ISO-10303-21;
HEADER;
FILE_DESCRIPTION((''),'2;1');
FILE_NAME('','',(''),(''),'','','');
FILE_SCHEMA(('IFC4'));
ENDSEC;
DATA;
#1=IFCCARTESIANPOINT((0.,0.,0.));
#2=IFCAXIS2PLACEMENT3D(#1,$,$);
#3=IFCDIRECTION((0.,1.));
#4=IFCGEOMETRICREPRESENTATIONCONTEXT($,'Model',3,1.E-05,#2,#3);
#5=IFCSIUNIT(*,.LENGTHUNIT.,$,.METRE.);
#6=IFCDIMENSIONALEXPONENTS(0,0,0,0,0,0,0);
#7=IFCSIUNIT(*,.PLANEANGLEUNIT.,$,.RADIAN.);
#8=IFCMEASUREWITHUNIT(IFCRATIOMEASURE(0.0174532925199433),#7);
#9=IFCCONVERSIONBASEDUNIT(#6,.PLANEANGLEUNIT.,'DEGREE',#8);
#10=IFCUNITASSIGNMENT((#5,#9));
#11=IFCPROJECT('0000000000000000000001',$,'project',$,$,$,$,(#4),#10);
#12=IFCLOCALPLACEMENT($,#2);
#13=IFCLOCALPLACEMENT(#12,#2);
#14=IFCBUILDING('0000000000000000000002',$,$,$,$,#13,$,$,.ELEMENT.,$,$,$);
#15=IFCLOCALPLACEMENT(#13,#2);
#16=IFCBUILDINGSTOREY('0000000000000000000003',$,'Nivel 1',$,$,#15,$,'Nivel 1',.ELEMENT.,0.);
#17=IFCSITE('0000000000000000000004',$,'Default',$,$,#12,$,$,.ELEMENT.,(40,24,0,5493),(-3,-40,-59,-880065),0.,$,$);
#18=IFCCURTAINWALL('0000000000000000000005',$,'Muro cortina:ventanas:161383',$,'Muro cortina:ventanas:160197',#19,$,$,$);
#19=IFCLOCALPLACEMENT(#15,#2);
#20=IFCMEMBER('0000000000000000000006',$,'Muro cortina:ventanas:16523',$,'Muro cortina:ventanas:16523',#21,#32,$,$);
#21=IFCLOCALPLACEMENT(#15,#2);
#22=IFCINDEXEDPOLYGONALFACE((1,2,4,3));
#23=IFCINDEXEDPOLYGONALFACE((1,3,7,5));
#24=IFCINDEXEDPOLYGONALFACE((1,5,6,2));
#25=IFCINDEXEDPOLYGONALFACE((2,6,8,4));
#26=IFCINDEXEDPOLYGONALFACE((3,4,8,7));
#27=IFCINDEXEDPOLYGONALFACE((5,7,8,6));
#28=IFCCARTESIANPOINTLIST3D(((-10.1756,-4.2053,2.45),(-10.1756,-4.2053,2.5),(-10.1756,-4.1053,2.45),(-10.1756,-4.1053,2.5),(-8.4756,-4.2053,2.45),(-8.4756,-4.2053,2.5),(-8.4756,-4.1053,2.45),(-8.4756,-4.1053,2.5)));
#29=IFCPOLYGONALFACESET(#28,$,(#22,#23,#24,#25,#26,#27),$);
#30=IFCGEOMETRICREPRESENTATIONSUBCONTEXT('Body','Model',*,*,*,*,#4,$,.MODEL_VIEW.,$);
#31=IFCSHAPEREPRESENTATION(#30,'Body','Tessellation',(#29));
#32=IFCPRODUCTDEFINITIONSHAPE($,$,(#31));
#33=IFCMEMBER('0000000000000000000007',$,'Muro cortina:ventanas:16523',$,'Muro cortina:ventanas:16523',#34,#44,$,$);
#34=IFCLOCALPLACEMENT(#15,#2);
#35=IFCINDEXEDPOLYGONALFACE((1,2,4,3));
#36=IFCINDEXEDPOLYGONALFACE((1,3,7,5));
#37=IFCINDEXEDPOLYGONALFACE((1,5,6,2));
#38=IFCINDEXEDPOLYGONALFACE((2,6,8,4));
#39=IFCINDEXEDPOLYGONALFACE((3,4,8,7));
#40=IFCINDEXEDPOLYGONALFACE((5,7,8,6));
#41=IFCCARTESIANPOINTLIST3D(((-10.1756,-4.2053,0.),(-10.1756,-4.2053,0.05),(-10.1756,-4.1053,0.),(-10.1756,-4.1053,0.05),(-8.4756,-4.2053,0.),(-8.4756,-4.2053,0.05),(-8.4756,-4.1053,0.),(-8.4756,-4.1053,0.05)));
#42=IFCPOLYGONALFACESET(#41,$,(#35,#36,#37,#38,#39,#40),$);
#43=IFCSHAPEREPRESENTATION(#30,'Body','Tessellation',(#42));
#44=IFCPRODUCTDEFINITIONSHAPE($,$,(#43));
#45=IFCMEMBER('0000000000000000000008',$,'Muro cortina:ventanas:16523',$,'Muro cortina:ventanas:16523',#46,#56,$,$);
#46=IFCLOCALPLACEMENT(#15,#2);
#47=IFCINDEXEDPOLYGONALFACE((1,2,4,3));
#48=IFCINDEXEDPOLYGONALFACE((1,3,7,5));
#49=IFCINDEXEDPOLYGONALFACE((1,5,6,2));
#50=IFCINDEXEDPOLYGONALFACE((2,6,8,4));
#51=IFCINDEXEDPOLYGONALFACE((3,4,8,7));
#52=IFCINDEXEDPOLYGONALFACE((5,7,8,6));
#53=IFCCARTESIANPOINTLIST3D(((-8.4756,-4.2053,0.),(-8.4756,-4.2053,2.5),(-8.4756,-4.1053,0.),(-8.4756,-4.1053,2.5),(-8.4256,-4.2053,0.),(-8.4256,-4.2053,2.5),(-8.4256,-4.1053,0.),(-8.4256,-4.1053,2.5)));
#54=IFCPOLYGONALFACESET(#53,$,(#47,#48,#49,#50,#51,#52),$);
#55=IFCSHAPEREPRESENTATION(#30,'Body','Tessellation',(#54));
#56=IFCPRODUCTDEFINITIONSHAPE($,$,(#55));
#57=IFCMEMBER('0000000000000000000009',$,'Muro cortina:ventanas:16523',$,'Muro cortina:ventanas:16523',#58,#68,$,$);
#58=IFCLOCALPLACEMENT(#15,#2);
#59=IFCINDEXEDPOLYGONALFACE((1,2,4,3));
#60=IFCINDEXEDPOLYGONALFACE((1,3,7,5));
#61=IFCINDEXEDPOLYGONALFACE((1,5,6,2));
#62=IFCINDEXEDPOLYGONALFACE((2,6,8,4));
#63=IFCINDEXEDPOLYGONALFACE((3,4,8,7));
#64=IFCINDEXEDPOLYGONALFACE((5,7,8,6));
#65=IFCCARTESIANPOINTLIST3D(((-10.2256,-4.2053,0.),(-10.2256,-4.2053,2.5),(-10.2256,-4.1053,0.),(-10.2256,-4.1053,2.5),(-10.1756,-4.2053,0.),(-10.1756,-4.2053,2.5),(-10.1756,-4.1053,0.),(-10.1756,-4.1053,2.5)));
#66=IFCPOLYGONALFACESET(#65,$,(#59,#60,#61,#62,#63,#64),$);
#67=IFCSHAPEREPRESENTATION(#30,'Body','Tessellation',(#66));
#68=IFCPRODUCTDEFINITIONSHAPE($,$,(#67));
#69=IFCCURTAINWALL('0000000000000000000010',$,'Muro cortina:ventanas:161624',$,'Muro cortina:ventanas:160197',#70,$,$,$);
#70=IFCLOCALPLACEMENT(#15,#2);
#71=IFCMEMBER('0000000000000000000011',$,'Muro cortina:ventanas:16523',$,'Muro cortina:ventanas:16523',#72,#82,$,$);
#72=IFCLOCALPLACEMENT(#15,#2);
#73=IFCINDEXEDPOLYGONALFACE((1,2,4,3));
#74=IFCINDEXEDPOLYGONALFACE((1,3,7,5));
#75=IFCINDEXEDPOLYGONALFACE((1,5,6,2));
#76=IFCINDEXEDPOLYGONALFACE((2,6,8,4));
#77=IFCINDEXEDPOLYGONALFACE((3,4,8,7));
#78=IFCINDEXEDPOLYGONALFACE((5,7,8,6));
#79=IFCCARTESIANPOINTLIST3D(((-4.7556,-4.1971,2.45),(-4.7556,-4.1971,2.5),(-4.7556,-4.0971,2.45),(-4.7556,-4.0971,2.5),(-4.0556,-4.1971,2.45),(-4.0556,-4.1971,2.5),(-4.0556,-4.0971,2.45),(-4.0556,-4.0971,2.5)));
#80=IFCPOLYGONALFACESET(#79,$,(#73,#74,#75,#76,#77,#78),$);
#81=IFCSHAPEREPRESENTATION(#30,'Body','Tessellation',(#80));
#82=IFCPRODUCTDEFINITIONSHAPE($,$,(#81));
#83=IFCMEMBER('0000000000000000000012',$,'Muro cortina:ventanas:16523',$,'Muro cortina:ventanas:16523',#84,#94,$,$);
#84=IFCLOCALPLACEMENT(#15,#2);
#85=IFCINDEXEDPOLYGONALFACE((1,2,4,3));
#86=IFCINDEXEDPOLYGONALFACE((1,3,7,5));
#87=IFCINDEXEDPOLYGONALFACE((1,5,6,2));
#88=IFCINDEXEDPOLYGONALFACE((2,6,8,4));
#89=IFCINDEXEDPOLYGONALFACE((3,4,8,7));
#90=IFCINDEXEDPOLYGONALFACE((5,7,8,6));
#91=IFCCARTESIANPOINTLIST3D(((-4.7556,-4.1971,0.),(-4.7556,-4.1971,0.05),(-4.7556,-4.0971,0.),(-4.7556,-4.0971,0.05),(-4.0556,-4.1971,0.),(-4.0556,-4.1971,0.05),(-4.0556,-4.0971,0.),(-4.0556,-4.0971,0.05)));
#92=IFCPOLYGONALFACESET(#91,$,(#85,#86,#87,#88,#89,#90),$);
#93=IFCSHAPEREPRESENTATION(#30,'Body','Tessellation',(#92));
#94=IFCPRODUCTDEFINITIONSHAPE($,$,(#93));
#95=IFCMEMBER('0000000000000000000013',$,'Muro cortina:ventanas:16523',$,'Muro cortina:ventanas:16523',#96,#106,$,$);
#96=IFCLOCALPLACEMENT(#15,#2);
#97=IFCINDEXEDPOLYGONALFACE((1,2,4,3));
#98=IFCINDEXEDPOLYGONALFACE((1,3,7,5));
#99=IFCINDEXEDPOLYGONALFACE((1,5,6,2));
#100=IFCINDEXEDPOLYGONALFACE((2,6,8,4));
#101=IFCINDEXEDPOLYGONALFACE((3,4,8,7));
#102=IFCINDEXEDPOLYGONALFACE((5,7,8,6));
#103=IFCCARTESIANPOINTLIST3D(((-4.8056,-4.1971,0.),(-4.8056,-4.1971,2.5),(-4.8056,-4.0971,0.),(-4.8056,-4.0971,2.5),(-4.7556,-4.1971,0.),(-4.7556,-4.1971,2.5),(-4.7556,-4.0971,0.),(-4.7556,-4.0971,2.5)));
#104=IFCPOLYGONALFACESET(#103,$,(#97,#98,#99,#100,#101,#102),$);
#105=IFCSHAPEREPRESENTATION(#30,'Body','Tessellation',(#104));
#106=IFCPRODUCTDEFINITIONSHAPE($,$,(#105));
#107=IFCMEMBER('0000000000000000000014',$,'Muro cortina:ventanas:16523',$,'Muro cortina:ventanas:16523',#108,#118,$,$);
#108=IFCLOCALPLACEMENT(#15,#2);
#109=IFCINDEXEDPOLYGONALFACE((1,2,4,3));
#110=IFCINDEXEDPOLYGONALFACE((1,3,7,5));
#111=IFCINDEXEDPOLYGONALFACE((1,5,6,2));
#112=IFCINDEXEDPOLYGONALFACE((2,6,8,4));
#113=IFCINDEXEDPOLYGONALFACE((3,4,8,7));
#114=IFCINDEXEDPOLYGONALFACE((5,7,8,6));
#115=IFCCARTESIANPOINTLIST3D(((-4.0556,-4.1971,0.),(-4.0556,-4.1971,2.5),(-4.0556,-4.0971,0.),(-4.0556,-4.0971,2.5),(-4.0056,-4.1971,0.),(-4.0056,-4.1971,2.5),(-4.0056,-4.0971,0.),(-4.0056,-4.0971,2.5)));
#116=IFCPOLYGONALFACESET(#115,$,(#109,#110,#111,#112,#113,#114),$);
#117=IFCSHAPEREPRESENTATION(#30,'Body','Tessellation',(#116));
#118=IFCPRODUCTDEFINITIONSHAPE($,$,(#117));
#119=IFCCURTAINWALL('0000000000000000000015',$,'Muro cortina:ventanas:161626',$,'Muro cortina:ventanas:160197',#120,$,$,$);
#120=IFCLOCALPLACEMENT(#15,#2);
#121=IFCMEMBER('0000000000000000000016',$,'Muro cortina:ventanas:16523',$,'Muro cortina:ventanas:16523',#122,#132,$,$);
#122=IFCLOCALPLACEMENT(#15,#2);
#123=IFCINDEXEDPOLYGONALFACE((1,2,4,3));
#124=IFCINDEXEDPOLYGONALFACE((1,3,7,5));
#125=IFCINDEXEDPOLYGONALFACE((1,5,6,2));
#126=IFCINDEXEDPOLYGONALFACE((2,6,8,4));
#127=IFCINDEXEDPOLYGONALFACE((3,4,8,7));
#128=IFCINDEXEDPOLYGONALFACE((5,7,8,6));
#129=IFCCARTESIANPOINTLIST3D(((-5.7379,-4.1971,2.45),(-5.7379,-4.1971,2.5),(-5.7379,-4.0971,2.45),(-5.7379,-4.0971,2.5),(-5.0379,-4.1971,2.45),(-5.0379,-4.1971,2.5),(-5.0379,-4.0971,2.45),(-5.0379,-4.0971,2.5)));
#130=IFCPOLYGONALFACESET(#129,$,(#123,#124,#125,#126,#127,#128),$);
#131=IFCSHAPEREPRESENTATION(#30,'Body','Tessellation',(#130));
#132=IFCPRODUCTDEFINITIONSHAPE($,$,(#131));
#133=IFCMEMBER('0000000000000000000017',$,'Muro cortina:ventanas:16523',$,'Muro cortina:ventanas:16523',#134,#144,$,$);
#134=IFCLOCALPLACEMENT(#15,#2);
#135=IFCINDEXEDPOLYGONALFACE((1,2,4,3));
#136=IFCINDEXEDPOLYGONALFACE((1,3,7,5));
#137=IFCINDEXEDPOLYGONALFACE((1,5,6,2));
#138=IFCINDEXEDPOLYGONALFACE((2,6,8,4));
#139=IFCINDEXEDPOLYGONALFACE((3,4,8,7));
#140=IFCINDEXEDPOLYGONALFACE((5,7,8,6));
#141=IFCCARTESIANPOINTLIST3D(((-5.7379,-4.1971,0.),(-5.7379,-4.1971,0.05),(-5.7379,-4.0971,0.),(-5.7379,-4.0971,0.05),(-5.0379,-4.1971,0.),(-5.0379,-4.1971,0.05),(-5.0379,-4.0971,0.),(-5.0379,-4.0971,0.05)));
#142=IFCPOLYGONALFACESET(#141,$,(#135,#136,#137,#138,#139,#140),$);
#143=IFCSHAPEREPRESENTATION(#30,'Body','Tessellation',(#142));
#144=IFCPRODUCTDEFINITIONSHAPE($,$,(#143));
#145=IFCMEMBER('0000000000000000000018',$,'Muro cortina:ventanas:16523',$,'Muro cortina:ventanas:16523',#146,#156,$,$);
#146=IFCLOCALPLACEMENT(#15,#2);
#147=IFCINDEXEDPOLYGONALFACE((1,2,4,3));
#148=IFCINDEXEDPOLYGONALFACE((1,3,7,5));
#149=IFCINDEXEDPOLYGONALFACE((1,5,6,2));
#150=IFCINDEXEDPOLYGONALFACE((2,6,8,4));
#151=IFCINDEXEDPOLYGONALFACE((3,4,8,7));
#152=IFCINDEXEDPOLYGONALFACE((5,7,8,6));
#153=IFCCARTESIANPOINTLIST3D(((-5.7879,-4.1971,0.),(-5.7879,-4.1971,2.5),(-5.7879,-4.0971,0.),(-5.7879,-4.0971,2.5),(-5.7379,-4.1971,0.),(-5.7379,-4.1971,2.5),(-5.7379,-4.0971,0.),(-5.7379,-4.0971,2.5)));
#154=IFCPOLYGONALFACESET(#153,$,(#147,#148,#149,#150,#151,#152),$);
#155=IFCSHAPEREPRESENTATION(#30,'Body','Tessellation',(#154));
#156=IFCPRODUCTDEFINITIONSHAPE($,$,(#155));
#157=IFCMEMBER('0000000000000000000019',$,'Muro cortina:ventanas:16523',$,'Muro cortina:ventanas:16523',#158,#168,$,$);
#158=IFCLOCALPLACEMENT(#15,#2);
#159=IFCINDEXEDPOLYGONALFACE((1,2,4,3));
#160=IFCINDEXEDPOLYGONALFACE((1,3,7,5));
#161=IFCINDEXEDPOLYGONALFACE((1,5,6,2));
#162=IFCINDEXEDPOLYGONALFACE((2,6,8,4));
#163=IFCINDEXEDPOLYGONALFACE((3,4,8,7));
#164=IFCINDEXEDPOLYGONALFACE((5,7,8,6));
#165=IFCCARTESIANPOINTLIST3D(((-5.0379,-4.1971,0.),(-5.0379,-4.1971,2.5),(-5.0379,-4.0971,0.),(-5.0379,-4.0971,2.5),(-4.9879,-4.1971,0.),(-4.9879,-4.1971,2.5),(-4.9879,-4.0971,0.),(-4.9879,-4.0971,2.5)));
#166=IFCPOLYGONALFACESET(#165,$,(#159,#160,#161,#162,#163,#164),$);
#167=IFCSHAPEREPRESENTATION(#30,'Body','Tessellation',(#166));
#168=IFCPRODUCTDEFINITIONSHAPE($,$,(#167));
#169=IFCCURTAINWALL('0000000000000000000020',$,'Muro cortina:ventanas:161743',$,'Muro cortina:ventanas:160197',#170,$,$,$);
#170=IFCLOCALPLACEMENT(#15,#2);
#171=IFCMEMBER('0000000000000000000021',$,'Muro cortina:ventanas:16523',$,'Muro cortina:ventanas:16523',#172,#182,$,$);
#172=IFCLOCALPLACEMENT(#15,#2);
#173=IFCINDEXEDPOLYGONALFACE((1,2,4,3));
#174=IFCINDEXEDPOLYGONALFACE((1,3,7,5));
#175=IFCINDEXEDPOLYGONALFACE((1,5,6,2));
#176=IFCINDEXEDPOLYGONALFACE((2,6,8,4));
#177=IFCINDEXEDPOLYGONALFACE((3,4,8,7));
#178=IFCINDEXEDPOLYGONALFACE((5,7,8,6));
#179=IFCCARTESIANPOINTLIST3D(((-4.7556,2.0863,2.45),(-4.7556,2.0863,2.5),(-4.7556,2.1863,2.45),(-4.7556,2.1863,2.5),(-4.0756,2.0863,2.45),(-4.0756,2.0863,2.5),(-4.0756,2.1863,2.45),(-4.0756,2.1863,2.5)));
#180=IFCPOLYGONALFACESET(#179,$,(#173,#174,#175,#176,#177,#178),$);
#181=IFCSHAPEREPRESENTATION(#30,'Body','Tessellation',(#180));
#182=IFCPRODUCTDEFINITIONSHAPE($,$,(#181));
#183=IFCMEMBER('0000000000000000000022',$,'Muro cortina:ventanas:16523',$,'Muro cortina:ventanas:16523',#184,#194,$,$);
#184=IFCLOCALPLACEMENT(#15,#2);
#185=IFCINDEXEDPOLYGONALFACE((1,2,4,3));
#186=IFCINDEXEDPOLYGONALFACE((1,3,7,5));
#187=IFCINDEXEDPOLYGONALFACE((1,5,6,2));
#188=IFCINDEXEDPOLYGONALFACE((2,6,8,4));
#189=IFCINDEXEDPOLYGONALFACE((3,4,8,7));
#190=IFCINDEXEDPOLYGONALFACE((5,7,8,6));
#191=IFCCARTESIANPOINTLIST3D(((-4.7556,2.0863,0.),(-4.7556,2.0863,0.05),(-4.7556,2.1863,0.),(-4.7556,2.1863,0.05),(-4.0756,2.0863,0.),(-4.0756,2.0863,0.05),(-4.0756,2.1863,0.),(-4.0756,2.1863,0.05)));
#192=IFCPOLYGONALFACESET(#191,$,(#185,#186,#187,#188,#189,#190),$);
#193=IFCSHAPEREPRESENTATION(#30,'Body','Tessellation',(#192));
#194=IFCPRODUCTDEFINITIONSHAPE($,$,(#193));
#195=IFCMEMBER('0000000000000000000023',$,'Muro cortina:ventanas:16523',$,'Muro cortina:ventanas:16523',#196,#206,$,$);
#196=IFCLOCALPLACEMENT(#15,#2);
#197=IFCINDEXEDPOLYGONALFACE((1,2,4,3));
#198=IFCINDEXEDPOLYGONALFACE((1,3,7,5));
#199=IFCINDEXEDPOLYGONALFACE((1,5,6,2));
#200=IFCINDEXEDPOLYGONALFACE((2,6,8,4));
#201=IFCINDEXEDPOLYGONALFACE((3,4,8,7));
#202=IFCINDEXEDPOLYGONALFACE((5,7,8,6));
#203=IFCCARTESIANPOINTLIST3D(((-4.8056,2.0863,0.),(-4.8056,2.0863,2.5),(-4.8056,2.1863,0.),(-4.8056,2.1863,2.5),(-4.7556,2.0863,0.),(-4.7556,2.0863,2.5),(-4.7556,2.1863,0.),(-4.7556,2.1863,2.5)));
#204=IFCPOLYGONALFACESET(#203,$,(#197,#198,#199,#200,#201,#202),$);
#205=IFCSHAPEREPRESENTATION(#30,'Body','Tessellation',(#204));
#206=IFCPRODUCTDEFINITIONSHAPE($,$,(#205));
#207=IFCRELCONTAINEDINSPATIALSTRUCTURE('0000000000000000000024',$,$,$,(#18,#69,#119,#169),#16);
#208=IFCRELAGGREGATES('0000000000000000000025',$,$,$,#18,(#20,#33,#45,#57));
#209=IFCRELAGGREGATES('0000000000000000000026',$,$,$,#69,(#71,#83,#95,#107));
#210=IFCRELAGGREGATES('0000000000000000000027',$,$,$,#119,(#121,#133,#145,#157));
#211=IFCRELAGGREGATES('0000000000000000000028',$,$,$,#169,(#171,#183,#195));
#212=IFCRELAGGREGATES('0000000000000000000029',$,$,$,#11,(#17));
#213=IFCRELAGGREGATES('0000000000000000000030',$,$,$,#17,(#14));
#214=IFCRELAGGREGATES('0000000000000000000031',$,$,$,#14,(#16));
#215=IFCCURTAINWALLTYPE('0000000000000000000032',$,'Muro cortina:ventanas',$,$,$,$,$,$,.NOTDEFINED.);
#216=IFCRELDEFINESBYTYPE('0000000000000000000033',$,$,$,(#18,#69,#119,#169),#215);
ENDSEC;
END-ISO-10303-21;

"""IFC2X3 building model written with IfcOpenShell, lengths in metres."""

from ifc_helpers import new_model, entity, si_unit, converted_unit, direction, frame, frame_2d, origin, place, context, subcontext, project, spatial, rectangle, extrude, type_object, element, aggregate, save


model = new_model("IFC2X3")

# Units and contexts
model_context = context("Model", 3, precision=1e-05, world=origin(), true_north=direction((0.0, 1.0)))
body_context = subcontext(model_context, "Body", "Model", "MODEL_VIEW")
ifc_project = project(units=[si_unit("LENGTHUNIT", "METRE"), converted_unit("PLANEANGLEUNIT", "DEGREE", entity("IfcRatioMeasure", 0.0174532925199433), si_unit("PLANEANGLEUNIT", "RADIAN"), dimensions=[0, 0, 0, 0, 0, 0, 0])], contexts=[model_context])

# Site, building, storey
site_placement = place(None, origin())
site = spatial("IfcSite", under=ifc_project, at=site_placement, Name="Default", CompositionType="ELEMENT", RefLatitude=(40, 24, 0, 5493), RefLongitude=(-3, -40, -59, -880065), RefElevation=0.0)
building_placement = place(site_placement, origin())
building = spatial("IfcBuilding", under=site, at=building_placement, CompositionType="ELEMENT")
storey_placement = place(building_placement, origin())
storey = spatial("IfcBuildingStorey", under=building, at=storey_placement, Name="Nivel 1", LongName="Nivel 1", CompositionType="ELEMENT", Elevation=0.0)

# Curtain walls, members
curtain_wall_type = type_object("IfcCurtainWallType", Name="Muro cortina:ventanas", PredefinedType="NOTDEFINED")
curtain_wall_1_placement = place(storey_placement, origin())
curtain_wall_1 = element("IfcCurtainWall", 1, at=curtain_wall_1_placement, inside=storey, type_object=curtain_wall_type, Name="Muro cortina:ventanas:161383", ObjectType="Muro cortina:ventanas:160197")
member_1_placement = place(curtain_wall_1_placement, origin())
member_1 = element("IfcMember", 2, at=member_1_placement, Name="Muro cortina:ventanas:16523", ObjectType="Muro cortina:ventanas:16523", context=body_context, shape_type="SweptSolid", body=[
    extrude(rectangle(XDim=0.05, YDim=0.1, at=frame_2d((0.0, 0.0), x_axis=(1.0, 0.0))), frame((-8.4756, -4.1553, 2.475), z_axis=(-1.0, 0.0, 0.0), x_axis=(0.0, 0.0, -1.0)), (0.0, 0.0, 1.0), 1.7),
])
member_2_placement = place(curtain_wall_1_placement, origin())
member_2 = element("IfcMember", 3, at=member_2_placement, Name="Muro cortina:ventanas:16523", ObjectType="Muro cortina:ventanas:16523", context=body_context, shape_type="SweptSolid", body=[
    extrude(rectangle(XDim=0.05, YDim=0.1, at=frame_2d((0.0, 0.0), x_axis=(1.0, 0.0))), frame((-10.1756, -4.1553, 0.025), z_axis=(1.0, 0.0, 0.0), x_axis=(0.0, 0.0, -1.0)), (0.0, 0.0, 1.0), 1.7),
])
member_3_placement = place(curtain_wall_1_placement, origin())
member_3 = element("IfcMember", 4, at=member_3_placement, Name="Muro cortina:ventanas:16523", ObjectType="Muro cortina:ventanas:16523", context=body_context, shape_type="SweptSolid", body=[
    extrude(rectangle(XDim=0.05, YDim=0.1, at=frame_2d((0.0, 0.0), x_axis=(1.0, 0.0))), frame((-8.4506, -4.1553, 0.0), z_axis=(0.0, 0.0, 1.0), x_axis=(-1.0, 0.0, 0.0)), (0.0, 0.0, 1.0), 2.5),
])
member_4_placement = place(curtain_wall_1_placement, origin())
member_4 = element("IfcMember", 5, at=member_4_placement, Name="Muro cortina:ventanas:16523", ObjectType="Muro cortina:ventanas:16523", context=body_context, shape_type="SweptSolid", body=[
    extrude(rectangle(XDim=0.05, YDim=0.1, at=frame_2d((0.0, 0.0), x_axis=(1.0, 0.0))), frame((-10.2006, -4.1553, 2.5), z_axis=(0.0, 0.0, -1.0), x_axis=(-1.0, 0.0, 0.0)), (0.0, 0.0, 1.0), 2.5),
])
aggregate(curtain_wall_1, [member_1, member_2, member_3, member_4])
curtain_wall_2_placement = place(storey_placement, origin())
curtain_wall_2 = element("IfcCurtainWall", 6, at=curtain_wall_2_placement, inside=storey, type_object=curtain_wall_type, Name="Muro cortina:ventanas:161624", ObjectType="Muro cortina:ventanas:160197")
member_5_placement = place(curtain_wall_2_placement, origin())
member_5 = element("IfcMember", 7, at=member_5_placement, Name="Muro cortina:ventanas:16523", ObjectType="Muro cortina:ventanas:16523", context=body_context, shape_type="SweptSolid", body=[
    extrude(rectangle(XDim=0.05, YDim=0.1, at=frame_2d((0.0, 0.0), x_axis=(1.0, 0.0))), frame((-4.7556, -4.1471, 2.475), z_axis=(1.0, 0.0, 0.0), x_axis=(0.0, 0.0, -1.0)), (0.0, 0.0, 1.0), 0.7),
])
member_6_placement = place(curtain_wall_2_placement, origin())
member_6 = element("IfcMember", 8, at=member_6_placement, Name="Muro cortina:ventanas:16523", ObjectType="Muro cortina:ventanas:16523", context=body_context, shape_type="SweptSolid", body=[
    extrude(rectangle(XDim=0.05, YDim=0.1, at=frame_2d((0.0, 0.0), x_axis=(1.0, 0.0))), frame((-4.0556, -4.1471, 0.025), z_axis=(-1.0, 0.0, 0.0), x_axis=(0.0, 0.0, -1.0)), (0.0, 0.0, 1.0), 0.7),
])
member_7_placement = place(curtain_wall_2_placement, origin())
member_7 = element("IfcMember", 9, at=member_7_placement, Name="Muro cortina:ventanas:16523", ObjectType="Muro cortina:ventanas:16523", context=body_context, shape_type="SweptSolid", body=[
    extrude(rectangle(XDim=0.05, YDim=0.1, at=frame_2d((0.0, 0.0), x_axis=(1.0, 0.0))), frame((-4.7806, -4.1471, 0.0), z_axis=(0.0, 0.0, 1.0), x_axis=(-1.0, 0.0, 0.0)), (0.0, 0.0, 1.0), 2.5),
])
member_8_placement = place(curtain_wall_2_placement, origin())
member_8 = element("IfcMember", 10, at=member_8_placement, Name="Muro cortina:ventanas:16523", ObjectType="Muro cortina:ventanas:16523", context=body_context, shape_type="SweptSolid", body=[
    extrude(rectangle(XDim=0.05, YDim=0.1, at=frame_2d((0.0, 0.0), x_axis=(1.0, 0.0))), frame((-4.0306, -4.1471, 2.5), z_axis=(0.0, 0.0, -1.0), x_axis=(-1.0, 0.0, 0.0)), (0.0, 0.0, 1.0), 2.5),
])
aggregate(curtain_wall_2, [member_5, member_6, member_7, member_8])
curtain_wall_3_placement = place(storey_placement, origin())
curtain_wall_3 = element("IfcCurtainWall", 11, at=curtain_wall_3_placement, inside=storey, type_object=curtain_wall_type, Name="Muro cortina:ventanas:161626", ObjectType="Muro cortina:ventanas:160197")
member_9_placement = place(curtain_wall_3_placement, origin())
member_9 = element("IfcMember", 12, at=member_9_placement, Name="Muro cortina:ventanas:16523", ObjectType="Muro cortina:ventanas:16523", context=body_context, shape_type="SweptSolid", body=[
    extrude(rectangle(XDim=0.05, YDim=0.1, at=frame_2d((0.0, 0.0), x_axis=(1.0, 0.0))), frame((-5.7379, -4.1471, 2.475), z_axis=(1.0, 0.0, 0.0), x_axis=(0.0, 0.0, -1.0)), (0.0, 0.0, 1.0), 0.7),
])
member_10_placement = place(curtain_wall_3_placement, origin())
member_10 = element("IfcMember", 13, at=member_10_placement, Name="Muro cortina:ventanas:16523", ObjectType="Muro cortina:ventanas:16523", context=body_context, shape_type="SweptSolid", body=[
    extrude(rectangle(XDim=0.05, YDim=0.1, at=frame_2d((0.0, 0.0), x_axis=(1.0, 0.0))), frame((-5.0379, -4.1471, 0.025), z_axis=(-1.0, 0.0, 0.0), x_axis=(0.0, 0.0, -1.0)), (0.0, 0.0, 1.0), 0.7),
])
member_11_placement = place(curtain_wall_3_placement, origin())
member_11 = element("IfcMember", 14, at=member_11_placement, Name="Muro cortina:ventanas:16523", ObjectType="Muro cortina:ventanas:16523", context=body_context, shape_type="SweptSolid", body=[
    extrude(rectangle(XDim=0.05, YDim=0.1, at=frame_2d((0.0, 0.0), x_axis=(1.0, 0.0))), frame((-5.7629, -4.1471, 0.0), z_axis=(0.0, 0.0, 1.0), x_axis=(-1.0, 0.0, 0.0)), (0.0, 0.0, 1.0), 2.5),
])
member_12_placement = place(curtain_wall_3_placement, origin())
member_12 = element("IfcMember", 15, at=member_12_placement, Name="Muro cortina:ventanas:16523", ObjectType="Muro cortina:ventanas:16523", context=body_context, shape_type="SweptSolid", body=[
    extrude(rectangle(XDim=0.05, YDim=0.1, at=frame_2d((0.0, 0.0), x_axis=(1.0, 0.0))), frame((-5.0129, -4.1471, 2.5), z_axis=(0.0, 0.0, -1.0), x_axis=(-1.0, 0.0, 0.0)), (0.0, 0.0, 1.0), 2.5),
])
aggregate(curtain_wall_3, [member_9, member_10, member_11, member_12])
curtain_wall_4_placement = place(storey_placement, origin())
curtain_wall_4 = element("IfcCurtainWall", 16, at=curtain_wall_4_placement, inside=storey, type_object=curtain_wall_type, Name="Muro cortina:ventanas:161743", ObjectType="Muro cortina:ventanas:160197")
member_13_placement = place(curtain_wall_4_placement, origin())
member_13 = element("IfcMember", 17, at=member_13_placement, Name="Muro cortina:ventanas:16523", ObjectType="Muro cortina:ventanas:16523", context=body_context, shape_type="SweptSolid", body=[
    extrude(rectangle(XDim=0.05, YDim=0.1, at=frame_2d((0.0, 0.0), x_axis=(1.0, 0.0))), frame((-4.7556, 2.1363, 2.475), z_axis=(1.0, 0.0, 0.0), x_axis=(0.0, 0.0, -1.0)), (0.0, 0.0, 1.0), 0.68),
])
member_14_placement = place(curtain_wall_4_placement, origin())
member_14 = element("IfcMember", 18, at=member_14_placement, Name="Muro cortina:ventanas:16523", ObjectType="Muro cortina:ventanas:16523", context=body_context, shape_type="SweptSolid", body=[
    extrude(rectangle(XDim=0.05, YDim=0.1, at=frame_2d((0.0, 0.0), x_axis=(1.0, 0.0))), frame((-4.0756, 2.1363, 0.025), z_axis=(-1.0, 0.0, 0.0), x_axis=(0.0, 0.0, -1.0)), (0.0, 0.0, 1.0), 0.68),
])
member_15_placement = place(curtain_wall_4_placement, origin())
member_15 = element("IfcMember", 19, at=member_15_placement, Name="Muro cortina:ventanas:16523", ObjectType="Muro cortina:ventanas:16523", context=body_context, shape_type="SweptSolid", body=[
    extrude(rectangle(XDim=0.05, YDim=0.1, at=frame_2d((0.0, 0.0), x_axis=(1.0, 0.0))), frame((-4.7806, 2.1363, 0.0), z_axis=(0.0, 0.0, 1.0), x_axis=(-1.0, 0.0, 0.0)), (0.0, 0.0, 1.0), 2.5),
])
aggregate(curtain_wall_4, [member_13, member_14, member_15])

save(model, "model.ifc")
